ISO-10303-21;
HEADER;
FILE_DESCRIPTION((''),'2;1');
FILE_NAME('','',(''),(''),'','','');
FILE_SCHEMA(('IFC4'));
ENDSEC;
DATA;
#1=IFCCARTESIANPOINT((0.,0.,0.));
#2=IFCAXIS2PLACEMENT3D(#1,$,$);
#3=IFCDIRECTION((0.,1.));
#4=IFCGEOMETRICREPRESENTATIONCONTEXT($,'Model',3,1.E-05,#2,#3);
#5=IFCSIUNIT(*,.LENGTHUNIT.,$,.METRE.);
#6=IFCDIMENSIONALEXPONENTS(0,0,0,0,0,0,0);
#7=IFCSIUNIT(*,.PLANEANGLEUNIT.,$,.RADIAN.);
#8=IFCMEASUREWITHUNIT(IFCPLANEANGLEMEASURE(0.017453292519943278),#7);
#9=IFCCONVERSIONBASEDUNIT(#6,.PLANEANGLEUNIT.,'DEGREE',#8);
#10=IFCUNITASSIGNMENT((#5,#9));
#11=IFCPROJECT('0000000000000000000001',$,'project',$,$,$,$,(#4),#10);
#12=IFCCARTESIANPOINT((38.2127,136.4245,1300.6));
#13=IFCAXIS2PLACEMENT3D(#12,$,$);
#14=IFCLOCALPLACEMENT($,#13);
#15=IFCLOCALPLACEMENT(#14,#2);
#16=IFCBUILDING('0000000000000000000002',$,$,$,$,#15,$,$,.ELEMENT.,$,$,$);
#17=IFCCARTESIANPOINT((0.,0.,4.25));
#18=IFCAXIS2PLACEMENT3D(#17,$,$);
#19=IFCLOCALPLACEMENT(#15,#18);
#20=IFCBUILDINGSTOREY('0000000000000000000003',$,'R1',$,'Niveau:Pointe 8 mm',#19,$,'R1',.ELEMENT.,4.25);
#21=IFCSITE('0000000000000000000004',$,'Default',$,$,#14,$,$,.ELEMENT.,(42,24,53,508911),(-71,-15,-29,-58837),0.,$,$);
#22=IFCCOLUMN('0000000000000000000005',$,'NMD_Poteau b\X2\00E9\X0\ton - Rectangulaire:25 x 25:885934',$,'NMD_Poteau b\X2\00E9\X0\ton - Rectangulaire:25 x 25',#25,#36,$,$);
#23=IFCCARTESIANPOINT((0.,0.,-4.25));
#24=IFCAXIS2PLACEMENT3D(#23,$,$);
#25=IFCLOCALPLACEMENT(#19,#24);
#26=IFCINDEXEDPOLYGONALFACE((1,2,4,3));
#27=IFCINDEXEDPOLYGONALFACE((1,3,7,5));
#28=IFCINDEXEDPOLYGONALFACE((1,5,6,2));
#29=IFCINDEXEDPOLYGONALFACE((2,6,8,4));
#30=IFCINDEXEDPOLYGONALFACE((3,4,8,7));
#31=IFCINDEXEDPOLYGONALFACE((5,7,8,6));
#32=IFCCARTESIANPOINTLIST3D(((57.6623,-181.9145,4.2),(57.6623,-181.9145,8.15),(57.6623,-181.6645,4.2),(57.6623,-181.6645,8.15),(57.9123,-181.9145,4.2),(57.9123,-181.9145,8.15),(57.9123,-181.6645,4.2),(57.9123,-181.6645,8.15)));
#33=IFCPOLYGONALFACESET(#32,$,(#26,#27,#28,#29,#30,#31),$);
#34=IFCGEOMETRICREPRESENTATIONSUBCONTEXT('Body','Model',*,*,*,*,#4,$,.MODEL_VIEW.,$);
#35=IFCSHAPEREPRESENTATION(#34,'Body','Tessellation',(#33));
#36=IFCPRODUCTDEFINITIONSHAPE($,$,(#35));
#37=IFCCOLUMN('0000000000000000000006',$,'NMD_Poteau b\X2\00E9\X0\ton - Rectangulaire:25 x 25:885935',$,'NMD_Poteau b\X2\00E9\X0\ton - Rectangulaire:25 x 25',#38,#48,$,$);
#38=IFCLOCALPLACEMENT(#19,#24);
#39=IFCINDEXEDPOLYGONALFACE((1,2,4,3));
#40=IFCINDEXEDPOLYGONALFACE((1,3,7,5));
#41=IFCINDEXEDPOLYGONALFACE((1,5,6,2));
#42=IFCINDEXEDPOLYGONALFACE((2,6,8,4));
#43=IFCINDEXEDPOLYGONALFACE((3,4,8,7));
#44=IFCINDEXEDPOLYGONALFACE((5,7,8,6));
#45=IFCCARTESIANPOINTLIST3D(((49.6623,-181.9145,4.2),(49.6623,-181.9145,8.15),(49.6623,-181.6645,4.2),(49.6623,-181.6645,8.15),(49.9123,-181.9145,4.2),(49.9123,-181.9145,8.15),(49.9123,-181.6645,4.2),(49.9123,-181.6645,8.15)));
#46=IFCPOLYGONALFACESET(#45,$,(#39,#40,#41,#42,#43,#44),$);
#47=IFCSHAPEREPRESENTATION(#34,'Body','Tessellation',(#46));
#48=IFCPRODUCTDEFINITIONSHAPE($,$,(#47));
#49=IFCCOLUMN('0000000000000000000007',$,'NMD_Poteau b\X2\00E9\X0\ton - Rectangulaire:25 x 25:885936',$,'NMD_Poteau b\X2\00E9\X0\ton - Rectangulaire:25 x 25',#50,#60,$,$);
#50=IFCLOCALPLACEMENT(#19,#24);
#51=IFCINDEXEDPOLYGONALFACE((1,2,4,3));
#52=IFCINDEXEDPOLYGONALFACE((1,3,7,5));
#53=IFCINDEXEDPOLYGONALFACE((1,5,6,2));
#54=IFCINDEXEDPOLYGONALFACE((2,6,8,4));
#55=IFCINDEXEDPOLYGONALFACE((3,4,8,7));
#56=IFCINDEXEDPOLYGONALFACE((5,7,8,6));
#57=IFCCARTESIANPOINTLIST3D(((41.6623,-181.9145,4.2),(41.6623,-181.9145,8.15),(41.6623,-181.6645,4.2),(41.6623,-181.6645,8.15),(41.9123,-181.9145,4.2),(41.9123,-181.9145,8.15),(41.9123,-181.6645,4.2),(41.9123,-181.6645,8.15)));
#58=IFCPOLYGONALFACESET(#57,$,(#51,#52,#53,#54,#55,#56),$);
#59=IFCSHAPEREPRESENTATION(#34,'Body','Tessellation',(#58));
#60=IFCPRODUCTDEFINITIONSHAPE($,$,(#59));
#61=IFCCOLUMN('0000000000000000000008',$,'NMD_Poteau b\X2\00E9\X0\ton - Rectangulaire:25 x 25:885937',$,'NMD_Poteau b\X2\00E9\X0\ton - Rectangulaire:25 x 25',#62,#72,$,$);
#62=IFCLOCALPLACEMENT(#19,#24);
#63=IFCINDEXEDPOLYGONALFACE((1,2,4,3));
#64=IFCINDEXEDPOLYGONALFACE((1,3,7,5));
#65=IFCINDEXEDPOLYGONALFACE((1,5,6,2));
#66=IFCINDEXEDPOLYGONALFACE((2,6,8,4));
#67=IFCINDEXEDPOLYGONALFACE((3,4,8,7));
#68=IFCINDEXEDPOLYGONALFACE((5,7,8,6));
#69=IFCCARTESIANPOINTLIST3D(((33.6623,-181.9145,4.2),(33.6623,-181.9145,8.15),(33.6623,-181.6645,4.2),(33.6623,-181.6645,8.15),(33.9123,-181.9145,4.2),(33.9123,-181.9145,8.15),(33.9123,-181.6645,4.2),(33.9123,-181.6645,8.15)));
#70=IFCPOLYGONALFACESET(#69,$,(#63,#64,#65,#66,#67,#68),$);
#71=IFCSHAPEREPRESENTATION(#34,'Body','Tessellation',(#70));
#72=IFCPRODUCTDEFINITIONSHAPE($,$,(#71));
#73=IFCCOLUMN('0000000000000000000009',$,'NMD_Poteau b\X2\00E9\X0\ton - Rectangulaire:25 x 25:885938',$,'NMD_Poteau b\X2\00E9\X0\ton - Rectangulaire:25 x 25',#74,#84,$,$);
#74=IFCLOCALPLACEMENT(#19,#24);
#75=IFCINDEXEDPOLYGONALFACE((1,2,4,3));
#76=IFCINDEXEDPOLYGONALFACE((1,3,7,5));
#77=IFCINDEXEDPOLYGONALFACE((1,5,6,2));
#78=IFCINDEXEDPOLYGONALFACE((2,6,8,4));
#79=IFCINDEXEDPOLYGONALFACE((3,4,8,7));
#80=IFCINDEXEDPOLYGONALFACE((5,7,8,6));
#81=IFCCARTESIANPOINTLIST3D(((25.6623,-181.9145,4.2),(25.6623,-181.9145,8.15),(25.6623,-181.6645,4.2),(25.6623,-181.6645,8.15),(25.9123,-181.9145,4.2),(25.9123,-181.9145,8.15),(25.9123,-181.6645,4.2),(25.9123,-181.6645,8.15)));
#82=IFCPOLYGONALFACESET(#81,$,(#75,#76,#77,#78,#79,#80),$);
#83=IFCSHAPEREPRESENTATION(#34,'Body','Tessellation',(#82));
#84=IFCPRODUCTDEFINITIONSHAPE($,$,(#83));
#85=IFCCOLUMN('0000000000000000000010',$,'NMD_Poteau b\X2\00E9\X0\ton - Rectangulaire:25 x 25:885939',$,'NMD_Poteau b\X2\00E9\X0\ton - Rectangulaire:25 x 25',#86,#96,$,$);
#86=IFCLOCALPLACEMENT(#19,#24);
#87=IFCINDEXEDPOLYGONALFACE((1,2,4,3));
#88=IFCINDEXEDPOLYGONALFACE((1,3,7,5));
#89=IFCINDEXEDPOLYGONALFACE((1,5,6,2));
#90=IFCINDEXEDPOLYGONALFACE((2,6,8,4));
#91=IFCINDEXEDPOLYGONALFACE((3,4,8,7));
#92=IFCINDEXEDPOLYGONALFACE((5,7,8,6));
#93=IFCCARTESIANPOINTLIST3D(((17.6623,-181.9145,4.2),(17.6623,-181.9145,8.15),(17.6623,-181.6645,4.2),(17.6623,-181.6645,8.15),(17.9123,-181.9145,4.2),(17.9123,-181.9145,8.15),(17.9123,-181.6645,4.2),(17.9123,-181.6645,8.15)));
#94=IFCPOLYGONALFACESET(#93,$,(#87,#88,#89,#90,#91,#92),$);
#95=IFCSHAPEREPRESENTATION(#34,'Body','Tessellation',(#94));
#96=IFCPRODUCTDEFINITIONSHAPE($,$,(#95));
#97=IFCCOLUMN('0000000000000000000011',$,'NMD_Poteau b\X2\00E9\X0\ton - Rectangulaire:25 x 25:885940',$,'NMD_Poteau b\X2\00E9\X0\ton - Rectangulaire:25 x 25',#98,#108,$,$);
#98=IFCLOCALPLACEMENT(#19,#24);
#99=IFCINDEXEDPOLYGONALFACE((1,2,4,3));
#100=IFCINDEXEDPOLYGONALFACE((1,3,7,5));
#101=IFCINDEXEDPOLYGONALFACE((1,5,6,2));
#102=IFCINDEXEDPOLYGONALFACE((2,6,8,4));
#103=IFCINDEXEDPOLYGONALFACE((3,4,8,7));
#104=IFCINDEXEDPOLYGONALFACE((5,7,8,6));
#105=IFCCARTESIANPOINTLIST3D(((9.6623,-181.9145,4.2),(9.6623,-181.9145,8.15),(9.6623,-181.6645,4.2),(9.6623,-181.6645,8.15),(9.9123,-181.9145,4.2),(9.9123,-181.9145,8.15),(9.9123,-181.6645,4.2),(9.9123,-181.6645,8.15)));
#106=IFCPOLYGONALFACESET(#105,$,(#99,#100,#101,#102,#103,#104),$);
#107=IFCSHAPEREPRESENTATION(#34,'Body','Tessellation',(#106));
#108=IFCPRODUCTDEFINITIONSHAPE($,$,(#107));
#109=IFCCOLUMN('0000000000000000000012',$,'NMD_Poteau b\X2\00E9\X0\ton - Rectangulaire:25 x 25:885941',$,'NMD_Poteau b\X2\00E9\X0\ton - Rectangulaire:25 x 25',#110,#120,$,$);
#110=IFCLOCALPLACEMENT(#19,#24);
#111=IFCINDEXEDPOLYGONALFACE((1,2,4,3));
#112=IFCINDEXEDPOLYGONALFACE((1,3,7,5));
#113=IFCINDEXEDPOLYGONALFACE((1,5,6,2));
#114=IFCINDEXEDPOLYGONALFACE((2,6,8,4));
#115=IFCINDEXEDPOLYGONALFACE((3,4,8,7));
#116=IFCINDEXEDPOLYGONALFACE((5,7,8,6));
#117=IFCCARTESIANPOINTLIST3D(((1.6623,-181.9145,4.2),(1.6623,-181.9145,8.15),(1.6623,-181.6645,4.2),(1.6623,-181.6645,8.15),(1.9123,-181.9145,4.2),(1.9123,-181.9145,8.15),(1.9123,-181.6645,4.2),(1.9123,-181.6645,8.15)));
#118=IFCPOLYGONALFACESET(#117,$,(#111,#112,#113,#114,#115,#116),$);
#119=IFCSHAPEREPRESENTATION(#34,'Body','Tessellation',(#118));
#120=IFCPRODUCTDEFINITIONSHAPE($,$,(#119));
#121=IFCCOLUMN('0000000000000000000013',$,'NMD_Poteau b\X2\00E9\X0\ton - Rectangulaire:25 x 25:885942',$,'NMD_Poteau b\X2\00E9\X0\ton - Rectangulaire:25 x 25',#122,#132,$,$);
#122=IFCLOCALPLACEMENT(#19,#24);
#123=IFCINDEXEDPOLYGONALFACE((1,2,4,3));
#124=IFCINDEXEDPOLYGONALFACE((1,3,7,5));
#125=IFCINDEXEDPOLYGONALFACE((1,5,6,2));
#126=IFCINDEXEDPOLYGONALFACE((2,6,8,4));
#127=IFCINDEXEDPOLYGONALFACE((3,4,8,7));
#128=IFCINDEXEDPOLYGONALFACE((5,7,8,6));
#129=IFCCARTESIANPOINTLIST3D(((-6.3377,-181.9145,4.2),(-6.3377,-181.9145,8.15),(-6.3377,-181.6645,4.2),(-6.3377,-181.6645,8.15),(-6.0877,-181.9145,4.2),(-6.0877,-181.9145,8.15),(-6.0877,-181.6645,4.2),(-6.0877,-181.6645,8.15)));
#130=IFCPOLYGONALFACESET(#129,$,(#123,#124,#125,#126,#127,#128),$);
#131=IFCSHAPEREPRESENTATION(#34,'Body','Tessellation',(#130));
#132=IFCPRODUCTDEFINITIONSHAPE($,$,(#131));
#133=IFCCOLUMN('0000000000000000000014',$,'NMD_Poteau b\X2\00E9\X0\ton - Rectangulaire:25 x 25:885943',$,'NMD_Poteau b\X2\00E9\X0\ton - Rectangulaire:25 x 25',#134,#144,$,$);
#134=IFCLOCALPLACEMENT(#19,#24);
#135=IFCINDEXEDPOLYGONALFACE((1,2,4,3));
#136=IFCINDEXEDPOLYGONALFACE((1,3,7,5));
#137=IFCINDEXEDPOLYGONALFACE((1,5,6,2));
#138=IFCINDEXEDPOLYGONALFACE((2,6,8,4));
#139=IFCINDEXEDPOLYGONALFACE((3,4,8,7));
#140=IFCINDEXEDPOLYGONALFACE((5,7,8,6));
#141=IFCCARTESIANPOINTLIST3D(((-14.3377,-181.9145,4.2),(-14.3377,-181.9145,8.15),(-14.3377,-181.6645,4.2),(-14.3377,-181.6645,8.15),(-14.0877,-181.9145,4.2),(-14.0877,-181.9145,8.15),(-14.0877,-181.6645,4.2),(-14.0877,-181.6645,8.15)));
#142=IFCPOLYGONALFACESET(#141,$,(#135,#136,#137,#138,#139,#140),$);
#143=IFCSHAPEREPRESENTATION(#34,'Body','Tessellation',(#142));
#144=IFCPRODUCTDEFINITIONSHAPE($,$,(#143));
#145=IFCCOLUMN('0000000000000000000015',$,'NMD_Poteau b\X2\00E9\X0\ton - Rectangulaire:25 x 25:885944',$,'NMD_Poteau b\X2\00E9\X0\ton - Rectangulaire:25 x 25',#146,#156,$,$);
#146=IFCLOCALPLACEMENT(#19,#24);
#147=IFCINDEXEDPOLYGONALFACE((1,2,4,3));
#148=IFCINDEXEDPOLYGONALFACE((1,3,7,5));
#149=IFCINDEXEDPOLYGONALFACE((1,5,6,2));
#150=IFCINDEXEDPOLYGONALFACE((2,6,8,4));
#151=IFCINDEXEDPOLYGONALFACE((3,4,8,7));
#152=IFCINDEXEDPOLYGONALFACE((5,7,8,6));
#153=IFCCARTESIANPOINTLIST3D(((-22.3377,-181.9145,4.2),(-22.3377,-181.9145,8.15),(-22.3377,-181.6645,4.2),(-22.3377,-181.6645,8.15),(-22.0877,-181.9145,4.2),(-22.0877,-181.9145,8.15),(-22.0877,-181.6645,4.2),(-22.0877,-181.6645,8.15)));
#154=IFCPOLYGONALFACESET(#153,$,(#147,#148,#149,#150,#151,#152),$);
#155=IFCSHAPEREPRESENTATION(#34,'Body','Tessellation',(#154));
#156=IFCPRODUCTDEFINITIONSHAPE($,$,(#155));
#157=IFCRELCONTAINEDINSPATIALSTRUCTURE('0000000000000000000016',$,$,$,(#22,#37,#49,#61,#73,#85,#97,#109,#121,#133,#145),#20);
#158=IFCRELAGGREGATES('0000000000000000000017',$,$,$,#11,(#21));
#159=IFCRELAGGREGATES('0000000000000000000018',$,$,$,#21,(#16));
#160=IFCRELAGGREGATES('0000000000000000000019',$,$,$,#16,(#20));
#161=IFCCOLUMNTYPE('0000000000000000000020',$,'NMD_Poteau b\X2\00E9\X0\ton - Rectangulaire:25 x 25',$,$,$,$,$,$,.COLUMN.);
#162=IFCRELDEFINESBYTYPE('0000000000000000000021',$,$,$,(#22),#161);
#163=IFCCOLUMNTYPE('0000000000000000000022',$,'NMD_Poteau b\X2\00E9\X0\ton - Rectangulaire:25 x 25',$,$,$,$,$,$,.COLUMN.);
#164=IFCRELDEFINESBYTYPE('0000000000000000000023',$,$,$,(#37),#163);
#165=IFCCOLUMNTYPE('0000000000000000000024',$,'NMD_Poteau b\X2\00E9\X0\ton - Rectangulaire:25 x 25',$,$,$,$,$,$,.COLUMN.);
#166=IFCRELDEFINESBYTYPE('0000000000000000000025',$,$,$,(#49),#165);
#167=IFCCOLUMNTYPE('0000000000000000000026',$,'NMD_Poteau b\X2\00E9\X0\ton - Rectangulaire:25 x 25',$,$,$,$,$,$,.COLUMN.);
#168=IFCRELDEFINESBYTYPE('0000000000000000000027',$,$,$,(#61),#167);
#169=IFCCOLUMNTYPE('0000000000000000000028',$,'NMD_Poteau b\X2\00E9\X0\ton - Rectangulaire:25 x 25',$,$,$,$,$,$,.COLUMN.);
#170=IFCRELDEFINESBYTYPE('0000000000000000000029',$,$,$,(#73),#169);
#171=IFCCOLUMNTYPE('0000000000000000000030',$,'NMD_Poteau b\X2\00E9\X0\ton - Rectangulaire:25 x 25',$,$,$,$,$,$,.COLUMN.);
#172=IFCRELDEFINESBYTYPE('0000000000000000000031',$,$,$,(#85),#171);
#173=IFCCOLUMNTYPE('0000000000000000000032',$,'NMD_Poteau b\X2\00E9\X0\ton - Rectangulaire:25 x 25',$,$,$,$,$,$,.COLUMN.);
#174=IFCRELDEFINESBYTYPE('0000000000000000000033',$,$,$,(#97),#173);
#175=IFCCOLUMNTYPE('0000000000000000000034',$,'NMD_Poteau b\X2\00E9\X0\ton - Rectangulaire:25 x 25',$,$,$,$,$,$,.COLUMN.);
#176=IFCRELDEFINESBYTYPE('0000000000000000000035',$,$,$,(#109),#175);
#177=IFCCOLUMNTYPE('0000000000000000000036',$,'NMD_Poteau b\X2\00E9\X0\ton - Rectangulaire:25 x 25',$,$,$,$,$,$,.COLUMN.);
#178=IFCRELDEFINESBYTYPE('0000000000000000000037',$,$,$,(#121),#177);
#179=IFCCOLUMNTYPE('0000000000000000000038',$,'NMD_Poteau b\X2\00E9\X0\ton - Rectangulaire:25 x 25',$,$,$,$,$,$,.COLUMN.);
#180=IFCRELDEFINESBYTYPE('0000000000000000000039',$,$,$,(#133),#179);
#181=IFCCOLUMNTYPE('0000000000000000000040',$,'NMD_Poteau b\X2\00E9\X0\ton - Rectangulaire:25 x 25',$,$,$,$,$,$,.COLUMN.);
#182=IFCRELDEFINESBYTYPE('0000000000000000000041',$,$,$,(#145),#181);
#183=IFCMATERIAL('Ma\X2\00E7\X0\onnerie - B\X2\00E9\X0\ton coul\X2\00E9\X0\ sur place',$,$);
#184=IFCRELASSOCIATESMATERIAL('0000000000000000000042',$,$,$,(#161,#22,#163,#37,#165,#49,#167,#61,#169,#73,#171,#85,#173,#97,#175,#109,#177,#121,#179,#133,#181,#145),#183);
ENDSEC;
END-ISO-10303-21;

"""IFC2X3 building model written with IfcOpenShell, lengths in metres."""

from ifc_helpers import new_model, entity, si_unit, converted_unit, direction, frame, frame_2d, origin, place, context, subcontext, project, spatial, rectangle, extrude, source, transform, mapped, material, type_object, type_shapes, element, save


model = new_model("IFC2X3")

# Units and contexts
model_context = context("Model", 3, precision=1e-05, world=origin(), true_north=direction((0.0, 1.0)))
body_context = subcontext(model_context, "Body", "Model", "MODEL_VIEW")
ifc_project = project(units=[si_unit("LENGTHUNIT", "METRE"), converted_unit("PLANEANGLEUNIT", "DEGREE", entity("IfcPlaneAngleMeasure", 0.017453292519943278), si_unit("PLANEANGLEUNIT", "RADIAN"), dimensions=[0, 0, 0, 0, 0, 0, 0])], contexts=[model_context])

# Site, building, storey
site_placement = place(None, frame((38.2127, 136.4245, 1300.6)))
site = spatial("IfcSite", under=ifc_project, at=site_placement, Name="Default", CompositionType="ELEMENT", RefLatitude=(42, 24, 53, 508911), RefLongitude=(-71, -15, -29, -58837), RefElevation=0.0)
building_placement = place(site_placement, origin())
building = spatial("IfcBuilding", under=site, at=building_placement, CompositionType="ELEMENT")
storey_placement = place(building_placement, frame((0.0, 0.0, 4.25)))
storey = spatial("IfcBuildingStorey", under=building, at=storey_placement, Name="R1", ObjectType="Niveau:Pointe 8 mm", LongName="R1", CompositionType="ELEMENT", Elevation=4.25)

# Columns
ifc_material = material(Name="Maçonnerie - Béton coulé sur place")
column_type_1 = type_object("IfcColumnType", Name="NMD_Poteau béton - Rectangulaire:25 x 25", PredefinedType="COLUMN", material=ifc_material)
shared_shape_1 = source(origin(), body_context, "Body", "SweptSolid", [
    extrude(rectangle(XDim=0.25, YDim=0.25, at=frame_2d((0.0, 0.0), x_axis=(1.0, 0.0))), frame((57.7873, -181.7895, 4.2), z_axis=(0.0, 0.0, 1.0), x_axis=(-1.0, 0.0, 0.0)), (0.0, 0.0, 1.0), 3.95),
])
type_shapes(column_type_1, [shared_shape_1])
column_1_placement = place(storey_placement, frame((0.0, 0.0, -4.25)))
element("IfcColumn", 1, at=column_1_placement, inside=storey, type_object=column_type_1, material=ifc_material, Name="NMD_Poteau béton - Rectangulaire:25 x 25:885934", ObjectType="NMD_Poteau béton - Rectangulaire:25 x 25", context=body_context, shape_type="MappedRepresentation", body=[
    mapped(shared_shape_1, transform((0.0, 0.0, 0.0), scale=1.0)),
])
column_type_2 = type_object("IfcColumnType", Name="NMD_Poteau béton - Rectangulaire:25 x 25", PredefinedType="COLUMN", material=ifc_material)
shared_shape_2 = source(origin(), body_context, "Body", "SweptSolid", [
    extrude(rectangle(XDim=0.25, YDim=0.25, at=frame_2d((0.0, 0.0), x_axis=(1.0, 0.0))), frame((49.7873, -181.7895, 4.2), z_axis=(0.0, 0.0, 1.0), x_axis=(-1.0, 0.0, 0.0)), (0.0, 0.0, 1.0), 3.95),
])
type_shapes(column_type_2, [shared_shape_2])
column_2_placement = place(storey_placement, frame((0.0, 0.0, -4.25)))
element("IfcColumn", 2, at=column_2_placement, inside=storey, type_object=column_type_2, material=ifc_material, Name="NMD_Poteau béton - Rectangulaire:25 x 25:885935", ObjectType="NMD_Poteau béton - Rectangulaire:25 x 25", context=body_context, shape_type="MappedRepresentation", body=[
    mapped(shared_shape_2, transform((0.0, 0.0, 0.0), scale=1.0)),
])
column_type_3 = type_object("IfcColumnType", Name="NMD_Poteau béton - Rectangulaire:25 x 25", PredefinedType="COLUMN", material=ifc_material)
shared_shape_3 = source(origin(), body_context, "Body", "SweptSolid", [
    extrude(rectangle(XDim=0.25, YDim=0.25, at=frame_2d((0.0, 0.0), x_axis=(1.0, 0.0))), frame((41.7873, -181.7895, 4.2), z_axis=(0.0, 0.0, 1.0), x_axis=(-1.0, 0.0, 0.0)), (0.0, 0.0, 1.0), 3.95),
])
type_shapes(column_type_3, [shared_shape_3])
column_3_placement = place(storey_placement, frame((0.0, 0.0, -4.25)))
element("IfcColumn", 3, at=column_3_placement, inside=storey, type_object=column_type_3, material=ifc_material, Name="NMD_Poteau béton - Rectangulaire:25 x 25:885936", ObjectType="NMD_Poteau béton - Rectangulaire:25 x 25", context=body_context, shape_type="MappedRepresentation", body=[
    mapped(shared_shape_3, transform((0.0, 0.0, 0.0), scale=1.0)),
])
column_type_4 = type_object("IfcColumnType", Name="NMD_Poteau béton - Rectangulaire:25 x 25", PredefinedType="COLUMN", material=ifc_material)
shared_shape_4 = source(origin(), body_context, "Body", "SweptSolid", [
    extrude(rectangle(XDim=0.25, YDim=0.25, at=frame_2d((0.0, 0.0), x_axis=(1.0, 0.0))), frame((33.7873, -181.7895, 4.2), z_axis=(0.0, 0.0, 1.0), x_axis=(-1.0, 0.0, 0.0)), (0.0, 0.0, 1.0), 3.95),
])
type_shapes(column_type_4, [shared_shape_4])
column_4_placement = place(storey_placement, frame((0.0, 0.0, -4.25)))
element("IfcColumn", 4, at=column_4_placement, inside=storey, type_object=column_type_4, material=ifc_material, Name="NMD_Poteau béton - Rectangulaire:25 x 25:885937", ObjectType="NMD_Poteau béton - Rectangulaire:25 x 25", context=body_context, shape_type="MappedRepresentation", body=[
    mapped(shared_shape_4, transform((0.0, 0.0, 0.0), scale=1.0)),
])
column_type_5 = type_object("IfcColumnType", Name="NMD_Poteau béton - Rectangulaire:25 x 25", PredefinedType="COLUMN", material=ifc_material)
shared_shape_5 = source(origin(), body_context, "Body", "SweptSolid", [
    extrude(rectangle(XDim=0.25, YDim=0.25, at=frame_2d((0.0, 0.0), x_axis=(1.0, 0.0))), frame((25.7873, -181.7895, 4.2), z_axis=(0.0, 0.0, 1.0), x_axis=(-1.0, 0.0, 0.0)), (0.0, 0.0, 1.0), 3.95),
])
type_shapes(column_type_5, [shared_shape_5])
column_5_placement = place(storey_placement, frame((0.0, 0.0, -4.25)))
element("IfcColumn", 5, at=column_5_placement, inside=storey, type_object=column_type_5, material=ifc_material, Name="NMD_Poteau béton - Rectangulaire:25 x 25:885938", ObjectType="NMD_Poteau béton - Rectangulaire:25 x 25", context=body_context, shape_type="MappedRepresentation", body=[
    mapped(shared_shape_5, transform((0.0, 0.0, 0.0), scale=1.0)),
])
column_type_6 = type_object("IfcColumnType", Name="NMD_Poteau béton - Rectangulaire:25 x 25", PredefinedType="COLUMN", material=ifc_material)
shared_shape_6 = source(origin(), body_context, "Body", "SweptSolid", [
    extrude(rectangle(XDim=0.25, YDim=0.25, at=frame_2d((0.0, 0.0), x_axis=(1.0, 0.0))), frame((17.7873, -181.7895, 4.2), z_axis=(0.0, 0.0, 1.0), x_axis=(-1.0, 0.0, 0.0)), (0.0, 0.0, 1.0), 3.95),
])
type_shapes(column_type_6, [shared_shape_6])
column_6_placement = place(storey_placement, frame((0.0, 0.0, -4.25)))
element("IfcColumn", 6, at=column_6_placement, inside=storey, type_object=column_type_6, material=ifc_material, Name="NMD_Poteau béton - Rectangulaire:25 x 25:885939", ObjectType="NMD_Poteau béton - Rectangulaire:25 x 25", context=body_context, shape_type="MappedRepresentation", body=[
    mapped(shared_shape_6, transform((0.0, 0.0, 0.0), scale=1.0)),
])
column_type_7 = type_object("IfcColumnType", Name="NMD_Poteau béton - Rectangulaire:25 x 25", PredefinedType="COLUMN", material=ifc_material)
shared_shape_7 = source(origin(), body_context, "Body", "SweptSolid", [
    extrude(rectangle(XDim=0.25, YDim=0.25, at=frame_2d((0.0, 0.0), x_axis=(1.0, 0.0))), frame((9.7873, -181.7895, 4.2), z_axis=(0.0, 0.0, 1.0), x_axis=(-1.0, 0.0, 0.0)), (0.0, 0.0, 1.0), 3.95),
])
type_shapes(column_type_7, [shared_shape_7])
column_7_placement = place(storey_placement, frame((0.0, 0.0, -4.25)))
element("IfcColumn", 7, at=column_7_placement, inside=storey, type_object=column_type_7, material=ifc_material, Name="NMD_Poteau béton - Rectangulaire:25 x 25:885940", ObjectType="NMD_Poteau béton - Rectangulaire:25 x 25", context=body_context, shape_type="MappedRepresentation", body=[
    mapped(shared_shape_7, transform((0.0, 0.0, 0.0), scale=1.0)),
])
column_type_8 = type_object("IfcColumnType", Name="NMD_Poteau béton - Rectangulaire:25 x 25", PredefinedType="COLUMN", material=ifc_material)
shared_shape_8 = source(origin(), body_context, "Body", "SweptSolid", [
    extrude(rectangle(XDim=0.25, YDim=0.25, at=frame_2d((0.0, 0.0), x_axis=(1.0, 0.0))), frame((1.7873, -181.7895, 4.2), z_axis=(0.0, 0.0, 1.0), x_axis=(-1.0, 0.0, 0.0)), (0.0, 0.0, 1.0), 3.95),
])
type_shapes(column_type_8, [shared_shape_8])
column_8_placement = place(storey_placement, frame((0.0, 0.0, -4.25)))
element("IfcColumn", 8, at=column_8_placement, inside=storey, type_object=column_type_8, material=ifc_material, Name="NMD_Poteau béton - Rectangulaire:25 x 25:885941", ObjectType="NMD_Poteau béton - Rectangulaire:25 x 25", context=body_context, shape_type="MappedRepresentation", body=[
    mapped(shared_shape_8, transform((0.0, 0.0, 0.0), scale=1.0)),
])
column_type_9 = type_object("IfcColumnType", Name="NMD_Poteau béton - Rectangulaire:25 x 25", PredefinedType="COLUMN", material=ifc_material)
shared_shape_9 = source(origin(), body_context, "Body", "SweptSolid", [
    extrude(rectangle(XDim=0.25, YDim=0.25, at=frame_2d((0.0, 0.0), x_axis=(1.0, 0.0))), frame((-6.2127, -181.7895, 4.2), z_axis=(0.0, 0.0, 1.0), x_axis=(-1.0, 0.0, 0.0)), (0.0, 0.0, 1.0), 3.95),
])
type_shapes(column_type_9, [shared_shape_9])
column_9_placement = place(storey_placement, frame((0.0, 0.0, -4.25)))
element("IfcColumn", 9, at=column_9_placement, inside=storey, type_object=column_type_9, material=ifc_material, Name="NMD_Poteau béton - Rectangulaire:25 x 25:885942", ObjectType="NMD_Poteau béton - Rectangulaire:25 x 25", context=body_context, shape_type="MappedRepresentation", body=[
    mapped(shared_shape_9, transform((0.0, 0.0, 0.0), scale=1.0)),
])
column_type_10 = type_object("IfcColumnType", Name="NMD_Poteau béton - Rectangulaire:25 x 25", PredefinedType="COLUMN", material=ifc_material)
shared_shape_10 = source(origin(), body_context, "Body", "SweptSolid", [
    extrude(rectangle(XDim=0.25, YDim=0.25, at=frame_2d((0.0, 0.0), x_axis=(1.0, 0.0))), frame((-14.2127, -181.7895, 4.2), z_axis=(0.0, 0.0, 1.0), x_axis=(-1.0, 0.0, 0.0)), (0.0, 0.0, 1.0), 3.95),
])
type_shapes(column_type_10, [shared_shape_10])
column_10_placement = place(storey_placement, frame((0.0, 0.0, -4.25)))
element("IfcColumn", 10, at=column_10_placement, inside=storey, type_object=column_type_10, material=ifc_material, Name="NMD_Poteau béton - Rectangulaire:25 x 25:885943", ObjectType="NMD_Poteau béton - Rectangulaire:25 x 25", context=body_context, shape_type="MappedRepresentation", body=[
    mapped(shared_shape_10, transform((0.0, 0.0, 0.0), scale=1.0)),
])
column_type_11 = type_object("IfcColumnType", Name="NMD_Poteau béton - Rectangulaire:25 x 25", PredefinedType="COLUMN", material=ifc_material)
shared_shape_11 = source(origin(), body_context, "Body", "SweptSolid", [
    extrude(rectangle(XDim=0.25, YDim=0.25, at=frame_2d((0.0, 0.0), x_axis=(1.0, 0.0))), frame((-22.2127, -181.7895, 4.2), z_axis=(0.0, 0.0, 1.0), x_axis=(-1.0, 0.0, 0.0)), (0.0, 0.0, 1.0), 3.95),
])
type_shapes(column_type_11, [shared_shape_11])
column_11_placement = place(storey_placement, frame((0.0, 0.0, -4.25)))
element("IfcColumn", 11, at=column_11_placement, inside=storey, type_object=column_type_11, material=ifc_material, Name="NMD_Poteau béton - Rectangulaire:25 x 25:885944", ObjectType="NMD_Poteau béton - Rectangulaire:25 x 25", context=body_context, shape_type="MappedRepresentation", body=[
    mapped(shared_shape_11, transform((0.0, 0.0, 0.0), scale=1.0)),
])

save(model, "model.ifc")
